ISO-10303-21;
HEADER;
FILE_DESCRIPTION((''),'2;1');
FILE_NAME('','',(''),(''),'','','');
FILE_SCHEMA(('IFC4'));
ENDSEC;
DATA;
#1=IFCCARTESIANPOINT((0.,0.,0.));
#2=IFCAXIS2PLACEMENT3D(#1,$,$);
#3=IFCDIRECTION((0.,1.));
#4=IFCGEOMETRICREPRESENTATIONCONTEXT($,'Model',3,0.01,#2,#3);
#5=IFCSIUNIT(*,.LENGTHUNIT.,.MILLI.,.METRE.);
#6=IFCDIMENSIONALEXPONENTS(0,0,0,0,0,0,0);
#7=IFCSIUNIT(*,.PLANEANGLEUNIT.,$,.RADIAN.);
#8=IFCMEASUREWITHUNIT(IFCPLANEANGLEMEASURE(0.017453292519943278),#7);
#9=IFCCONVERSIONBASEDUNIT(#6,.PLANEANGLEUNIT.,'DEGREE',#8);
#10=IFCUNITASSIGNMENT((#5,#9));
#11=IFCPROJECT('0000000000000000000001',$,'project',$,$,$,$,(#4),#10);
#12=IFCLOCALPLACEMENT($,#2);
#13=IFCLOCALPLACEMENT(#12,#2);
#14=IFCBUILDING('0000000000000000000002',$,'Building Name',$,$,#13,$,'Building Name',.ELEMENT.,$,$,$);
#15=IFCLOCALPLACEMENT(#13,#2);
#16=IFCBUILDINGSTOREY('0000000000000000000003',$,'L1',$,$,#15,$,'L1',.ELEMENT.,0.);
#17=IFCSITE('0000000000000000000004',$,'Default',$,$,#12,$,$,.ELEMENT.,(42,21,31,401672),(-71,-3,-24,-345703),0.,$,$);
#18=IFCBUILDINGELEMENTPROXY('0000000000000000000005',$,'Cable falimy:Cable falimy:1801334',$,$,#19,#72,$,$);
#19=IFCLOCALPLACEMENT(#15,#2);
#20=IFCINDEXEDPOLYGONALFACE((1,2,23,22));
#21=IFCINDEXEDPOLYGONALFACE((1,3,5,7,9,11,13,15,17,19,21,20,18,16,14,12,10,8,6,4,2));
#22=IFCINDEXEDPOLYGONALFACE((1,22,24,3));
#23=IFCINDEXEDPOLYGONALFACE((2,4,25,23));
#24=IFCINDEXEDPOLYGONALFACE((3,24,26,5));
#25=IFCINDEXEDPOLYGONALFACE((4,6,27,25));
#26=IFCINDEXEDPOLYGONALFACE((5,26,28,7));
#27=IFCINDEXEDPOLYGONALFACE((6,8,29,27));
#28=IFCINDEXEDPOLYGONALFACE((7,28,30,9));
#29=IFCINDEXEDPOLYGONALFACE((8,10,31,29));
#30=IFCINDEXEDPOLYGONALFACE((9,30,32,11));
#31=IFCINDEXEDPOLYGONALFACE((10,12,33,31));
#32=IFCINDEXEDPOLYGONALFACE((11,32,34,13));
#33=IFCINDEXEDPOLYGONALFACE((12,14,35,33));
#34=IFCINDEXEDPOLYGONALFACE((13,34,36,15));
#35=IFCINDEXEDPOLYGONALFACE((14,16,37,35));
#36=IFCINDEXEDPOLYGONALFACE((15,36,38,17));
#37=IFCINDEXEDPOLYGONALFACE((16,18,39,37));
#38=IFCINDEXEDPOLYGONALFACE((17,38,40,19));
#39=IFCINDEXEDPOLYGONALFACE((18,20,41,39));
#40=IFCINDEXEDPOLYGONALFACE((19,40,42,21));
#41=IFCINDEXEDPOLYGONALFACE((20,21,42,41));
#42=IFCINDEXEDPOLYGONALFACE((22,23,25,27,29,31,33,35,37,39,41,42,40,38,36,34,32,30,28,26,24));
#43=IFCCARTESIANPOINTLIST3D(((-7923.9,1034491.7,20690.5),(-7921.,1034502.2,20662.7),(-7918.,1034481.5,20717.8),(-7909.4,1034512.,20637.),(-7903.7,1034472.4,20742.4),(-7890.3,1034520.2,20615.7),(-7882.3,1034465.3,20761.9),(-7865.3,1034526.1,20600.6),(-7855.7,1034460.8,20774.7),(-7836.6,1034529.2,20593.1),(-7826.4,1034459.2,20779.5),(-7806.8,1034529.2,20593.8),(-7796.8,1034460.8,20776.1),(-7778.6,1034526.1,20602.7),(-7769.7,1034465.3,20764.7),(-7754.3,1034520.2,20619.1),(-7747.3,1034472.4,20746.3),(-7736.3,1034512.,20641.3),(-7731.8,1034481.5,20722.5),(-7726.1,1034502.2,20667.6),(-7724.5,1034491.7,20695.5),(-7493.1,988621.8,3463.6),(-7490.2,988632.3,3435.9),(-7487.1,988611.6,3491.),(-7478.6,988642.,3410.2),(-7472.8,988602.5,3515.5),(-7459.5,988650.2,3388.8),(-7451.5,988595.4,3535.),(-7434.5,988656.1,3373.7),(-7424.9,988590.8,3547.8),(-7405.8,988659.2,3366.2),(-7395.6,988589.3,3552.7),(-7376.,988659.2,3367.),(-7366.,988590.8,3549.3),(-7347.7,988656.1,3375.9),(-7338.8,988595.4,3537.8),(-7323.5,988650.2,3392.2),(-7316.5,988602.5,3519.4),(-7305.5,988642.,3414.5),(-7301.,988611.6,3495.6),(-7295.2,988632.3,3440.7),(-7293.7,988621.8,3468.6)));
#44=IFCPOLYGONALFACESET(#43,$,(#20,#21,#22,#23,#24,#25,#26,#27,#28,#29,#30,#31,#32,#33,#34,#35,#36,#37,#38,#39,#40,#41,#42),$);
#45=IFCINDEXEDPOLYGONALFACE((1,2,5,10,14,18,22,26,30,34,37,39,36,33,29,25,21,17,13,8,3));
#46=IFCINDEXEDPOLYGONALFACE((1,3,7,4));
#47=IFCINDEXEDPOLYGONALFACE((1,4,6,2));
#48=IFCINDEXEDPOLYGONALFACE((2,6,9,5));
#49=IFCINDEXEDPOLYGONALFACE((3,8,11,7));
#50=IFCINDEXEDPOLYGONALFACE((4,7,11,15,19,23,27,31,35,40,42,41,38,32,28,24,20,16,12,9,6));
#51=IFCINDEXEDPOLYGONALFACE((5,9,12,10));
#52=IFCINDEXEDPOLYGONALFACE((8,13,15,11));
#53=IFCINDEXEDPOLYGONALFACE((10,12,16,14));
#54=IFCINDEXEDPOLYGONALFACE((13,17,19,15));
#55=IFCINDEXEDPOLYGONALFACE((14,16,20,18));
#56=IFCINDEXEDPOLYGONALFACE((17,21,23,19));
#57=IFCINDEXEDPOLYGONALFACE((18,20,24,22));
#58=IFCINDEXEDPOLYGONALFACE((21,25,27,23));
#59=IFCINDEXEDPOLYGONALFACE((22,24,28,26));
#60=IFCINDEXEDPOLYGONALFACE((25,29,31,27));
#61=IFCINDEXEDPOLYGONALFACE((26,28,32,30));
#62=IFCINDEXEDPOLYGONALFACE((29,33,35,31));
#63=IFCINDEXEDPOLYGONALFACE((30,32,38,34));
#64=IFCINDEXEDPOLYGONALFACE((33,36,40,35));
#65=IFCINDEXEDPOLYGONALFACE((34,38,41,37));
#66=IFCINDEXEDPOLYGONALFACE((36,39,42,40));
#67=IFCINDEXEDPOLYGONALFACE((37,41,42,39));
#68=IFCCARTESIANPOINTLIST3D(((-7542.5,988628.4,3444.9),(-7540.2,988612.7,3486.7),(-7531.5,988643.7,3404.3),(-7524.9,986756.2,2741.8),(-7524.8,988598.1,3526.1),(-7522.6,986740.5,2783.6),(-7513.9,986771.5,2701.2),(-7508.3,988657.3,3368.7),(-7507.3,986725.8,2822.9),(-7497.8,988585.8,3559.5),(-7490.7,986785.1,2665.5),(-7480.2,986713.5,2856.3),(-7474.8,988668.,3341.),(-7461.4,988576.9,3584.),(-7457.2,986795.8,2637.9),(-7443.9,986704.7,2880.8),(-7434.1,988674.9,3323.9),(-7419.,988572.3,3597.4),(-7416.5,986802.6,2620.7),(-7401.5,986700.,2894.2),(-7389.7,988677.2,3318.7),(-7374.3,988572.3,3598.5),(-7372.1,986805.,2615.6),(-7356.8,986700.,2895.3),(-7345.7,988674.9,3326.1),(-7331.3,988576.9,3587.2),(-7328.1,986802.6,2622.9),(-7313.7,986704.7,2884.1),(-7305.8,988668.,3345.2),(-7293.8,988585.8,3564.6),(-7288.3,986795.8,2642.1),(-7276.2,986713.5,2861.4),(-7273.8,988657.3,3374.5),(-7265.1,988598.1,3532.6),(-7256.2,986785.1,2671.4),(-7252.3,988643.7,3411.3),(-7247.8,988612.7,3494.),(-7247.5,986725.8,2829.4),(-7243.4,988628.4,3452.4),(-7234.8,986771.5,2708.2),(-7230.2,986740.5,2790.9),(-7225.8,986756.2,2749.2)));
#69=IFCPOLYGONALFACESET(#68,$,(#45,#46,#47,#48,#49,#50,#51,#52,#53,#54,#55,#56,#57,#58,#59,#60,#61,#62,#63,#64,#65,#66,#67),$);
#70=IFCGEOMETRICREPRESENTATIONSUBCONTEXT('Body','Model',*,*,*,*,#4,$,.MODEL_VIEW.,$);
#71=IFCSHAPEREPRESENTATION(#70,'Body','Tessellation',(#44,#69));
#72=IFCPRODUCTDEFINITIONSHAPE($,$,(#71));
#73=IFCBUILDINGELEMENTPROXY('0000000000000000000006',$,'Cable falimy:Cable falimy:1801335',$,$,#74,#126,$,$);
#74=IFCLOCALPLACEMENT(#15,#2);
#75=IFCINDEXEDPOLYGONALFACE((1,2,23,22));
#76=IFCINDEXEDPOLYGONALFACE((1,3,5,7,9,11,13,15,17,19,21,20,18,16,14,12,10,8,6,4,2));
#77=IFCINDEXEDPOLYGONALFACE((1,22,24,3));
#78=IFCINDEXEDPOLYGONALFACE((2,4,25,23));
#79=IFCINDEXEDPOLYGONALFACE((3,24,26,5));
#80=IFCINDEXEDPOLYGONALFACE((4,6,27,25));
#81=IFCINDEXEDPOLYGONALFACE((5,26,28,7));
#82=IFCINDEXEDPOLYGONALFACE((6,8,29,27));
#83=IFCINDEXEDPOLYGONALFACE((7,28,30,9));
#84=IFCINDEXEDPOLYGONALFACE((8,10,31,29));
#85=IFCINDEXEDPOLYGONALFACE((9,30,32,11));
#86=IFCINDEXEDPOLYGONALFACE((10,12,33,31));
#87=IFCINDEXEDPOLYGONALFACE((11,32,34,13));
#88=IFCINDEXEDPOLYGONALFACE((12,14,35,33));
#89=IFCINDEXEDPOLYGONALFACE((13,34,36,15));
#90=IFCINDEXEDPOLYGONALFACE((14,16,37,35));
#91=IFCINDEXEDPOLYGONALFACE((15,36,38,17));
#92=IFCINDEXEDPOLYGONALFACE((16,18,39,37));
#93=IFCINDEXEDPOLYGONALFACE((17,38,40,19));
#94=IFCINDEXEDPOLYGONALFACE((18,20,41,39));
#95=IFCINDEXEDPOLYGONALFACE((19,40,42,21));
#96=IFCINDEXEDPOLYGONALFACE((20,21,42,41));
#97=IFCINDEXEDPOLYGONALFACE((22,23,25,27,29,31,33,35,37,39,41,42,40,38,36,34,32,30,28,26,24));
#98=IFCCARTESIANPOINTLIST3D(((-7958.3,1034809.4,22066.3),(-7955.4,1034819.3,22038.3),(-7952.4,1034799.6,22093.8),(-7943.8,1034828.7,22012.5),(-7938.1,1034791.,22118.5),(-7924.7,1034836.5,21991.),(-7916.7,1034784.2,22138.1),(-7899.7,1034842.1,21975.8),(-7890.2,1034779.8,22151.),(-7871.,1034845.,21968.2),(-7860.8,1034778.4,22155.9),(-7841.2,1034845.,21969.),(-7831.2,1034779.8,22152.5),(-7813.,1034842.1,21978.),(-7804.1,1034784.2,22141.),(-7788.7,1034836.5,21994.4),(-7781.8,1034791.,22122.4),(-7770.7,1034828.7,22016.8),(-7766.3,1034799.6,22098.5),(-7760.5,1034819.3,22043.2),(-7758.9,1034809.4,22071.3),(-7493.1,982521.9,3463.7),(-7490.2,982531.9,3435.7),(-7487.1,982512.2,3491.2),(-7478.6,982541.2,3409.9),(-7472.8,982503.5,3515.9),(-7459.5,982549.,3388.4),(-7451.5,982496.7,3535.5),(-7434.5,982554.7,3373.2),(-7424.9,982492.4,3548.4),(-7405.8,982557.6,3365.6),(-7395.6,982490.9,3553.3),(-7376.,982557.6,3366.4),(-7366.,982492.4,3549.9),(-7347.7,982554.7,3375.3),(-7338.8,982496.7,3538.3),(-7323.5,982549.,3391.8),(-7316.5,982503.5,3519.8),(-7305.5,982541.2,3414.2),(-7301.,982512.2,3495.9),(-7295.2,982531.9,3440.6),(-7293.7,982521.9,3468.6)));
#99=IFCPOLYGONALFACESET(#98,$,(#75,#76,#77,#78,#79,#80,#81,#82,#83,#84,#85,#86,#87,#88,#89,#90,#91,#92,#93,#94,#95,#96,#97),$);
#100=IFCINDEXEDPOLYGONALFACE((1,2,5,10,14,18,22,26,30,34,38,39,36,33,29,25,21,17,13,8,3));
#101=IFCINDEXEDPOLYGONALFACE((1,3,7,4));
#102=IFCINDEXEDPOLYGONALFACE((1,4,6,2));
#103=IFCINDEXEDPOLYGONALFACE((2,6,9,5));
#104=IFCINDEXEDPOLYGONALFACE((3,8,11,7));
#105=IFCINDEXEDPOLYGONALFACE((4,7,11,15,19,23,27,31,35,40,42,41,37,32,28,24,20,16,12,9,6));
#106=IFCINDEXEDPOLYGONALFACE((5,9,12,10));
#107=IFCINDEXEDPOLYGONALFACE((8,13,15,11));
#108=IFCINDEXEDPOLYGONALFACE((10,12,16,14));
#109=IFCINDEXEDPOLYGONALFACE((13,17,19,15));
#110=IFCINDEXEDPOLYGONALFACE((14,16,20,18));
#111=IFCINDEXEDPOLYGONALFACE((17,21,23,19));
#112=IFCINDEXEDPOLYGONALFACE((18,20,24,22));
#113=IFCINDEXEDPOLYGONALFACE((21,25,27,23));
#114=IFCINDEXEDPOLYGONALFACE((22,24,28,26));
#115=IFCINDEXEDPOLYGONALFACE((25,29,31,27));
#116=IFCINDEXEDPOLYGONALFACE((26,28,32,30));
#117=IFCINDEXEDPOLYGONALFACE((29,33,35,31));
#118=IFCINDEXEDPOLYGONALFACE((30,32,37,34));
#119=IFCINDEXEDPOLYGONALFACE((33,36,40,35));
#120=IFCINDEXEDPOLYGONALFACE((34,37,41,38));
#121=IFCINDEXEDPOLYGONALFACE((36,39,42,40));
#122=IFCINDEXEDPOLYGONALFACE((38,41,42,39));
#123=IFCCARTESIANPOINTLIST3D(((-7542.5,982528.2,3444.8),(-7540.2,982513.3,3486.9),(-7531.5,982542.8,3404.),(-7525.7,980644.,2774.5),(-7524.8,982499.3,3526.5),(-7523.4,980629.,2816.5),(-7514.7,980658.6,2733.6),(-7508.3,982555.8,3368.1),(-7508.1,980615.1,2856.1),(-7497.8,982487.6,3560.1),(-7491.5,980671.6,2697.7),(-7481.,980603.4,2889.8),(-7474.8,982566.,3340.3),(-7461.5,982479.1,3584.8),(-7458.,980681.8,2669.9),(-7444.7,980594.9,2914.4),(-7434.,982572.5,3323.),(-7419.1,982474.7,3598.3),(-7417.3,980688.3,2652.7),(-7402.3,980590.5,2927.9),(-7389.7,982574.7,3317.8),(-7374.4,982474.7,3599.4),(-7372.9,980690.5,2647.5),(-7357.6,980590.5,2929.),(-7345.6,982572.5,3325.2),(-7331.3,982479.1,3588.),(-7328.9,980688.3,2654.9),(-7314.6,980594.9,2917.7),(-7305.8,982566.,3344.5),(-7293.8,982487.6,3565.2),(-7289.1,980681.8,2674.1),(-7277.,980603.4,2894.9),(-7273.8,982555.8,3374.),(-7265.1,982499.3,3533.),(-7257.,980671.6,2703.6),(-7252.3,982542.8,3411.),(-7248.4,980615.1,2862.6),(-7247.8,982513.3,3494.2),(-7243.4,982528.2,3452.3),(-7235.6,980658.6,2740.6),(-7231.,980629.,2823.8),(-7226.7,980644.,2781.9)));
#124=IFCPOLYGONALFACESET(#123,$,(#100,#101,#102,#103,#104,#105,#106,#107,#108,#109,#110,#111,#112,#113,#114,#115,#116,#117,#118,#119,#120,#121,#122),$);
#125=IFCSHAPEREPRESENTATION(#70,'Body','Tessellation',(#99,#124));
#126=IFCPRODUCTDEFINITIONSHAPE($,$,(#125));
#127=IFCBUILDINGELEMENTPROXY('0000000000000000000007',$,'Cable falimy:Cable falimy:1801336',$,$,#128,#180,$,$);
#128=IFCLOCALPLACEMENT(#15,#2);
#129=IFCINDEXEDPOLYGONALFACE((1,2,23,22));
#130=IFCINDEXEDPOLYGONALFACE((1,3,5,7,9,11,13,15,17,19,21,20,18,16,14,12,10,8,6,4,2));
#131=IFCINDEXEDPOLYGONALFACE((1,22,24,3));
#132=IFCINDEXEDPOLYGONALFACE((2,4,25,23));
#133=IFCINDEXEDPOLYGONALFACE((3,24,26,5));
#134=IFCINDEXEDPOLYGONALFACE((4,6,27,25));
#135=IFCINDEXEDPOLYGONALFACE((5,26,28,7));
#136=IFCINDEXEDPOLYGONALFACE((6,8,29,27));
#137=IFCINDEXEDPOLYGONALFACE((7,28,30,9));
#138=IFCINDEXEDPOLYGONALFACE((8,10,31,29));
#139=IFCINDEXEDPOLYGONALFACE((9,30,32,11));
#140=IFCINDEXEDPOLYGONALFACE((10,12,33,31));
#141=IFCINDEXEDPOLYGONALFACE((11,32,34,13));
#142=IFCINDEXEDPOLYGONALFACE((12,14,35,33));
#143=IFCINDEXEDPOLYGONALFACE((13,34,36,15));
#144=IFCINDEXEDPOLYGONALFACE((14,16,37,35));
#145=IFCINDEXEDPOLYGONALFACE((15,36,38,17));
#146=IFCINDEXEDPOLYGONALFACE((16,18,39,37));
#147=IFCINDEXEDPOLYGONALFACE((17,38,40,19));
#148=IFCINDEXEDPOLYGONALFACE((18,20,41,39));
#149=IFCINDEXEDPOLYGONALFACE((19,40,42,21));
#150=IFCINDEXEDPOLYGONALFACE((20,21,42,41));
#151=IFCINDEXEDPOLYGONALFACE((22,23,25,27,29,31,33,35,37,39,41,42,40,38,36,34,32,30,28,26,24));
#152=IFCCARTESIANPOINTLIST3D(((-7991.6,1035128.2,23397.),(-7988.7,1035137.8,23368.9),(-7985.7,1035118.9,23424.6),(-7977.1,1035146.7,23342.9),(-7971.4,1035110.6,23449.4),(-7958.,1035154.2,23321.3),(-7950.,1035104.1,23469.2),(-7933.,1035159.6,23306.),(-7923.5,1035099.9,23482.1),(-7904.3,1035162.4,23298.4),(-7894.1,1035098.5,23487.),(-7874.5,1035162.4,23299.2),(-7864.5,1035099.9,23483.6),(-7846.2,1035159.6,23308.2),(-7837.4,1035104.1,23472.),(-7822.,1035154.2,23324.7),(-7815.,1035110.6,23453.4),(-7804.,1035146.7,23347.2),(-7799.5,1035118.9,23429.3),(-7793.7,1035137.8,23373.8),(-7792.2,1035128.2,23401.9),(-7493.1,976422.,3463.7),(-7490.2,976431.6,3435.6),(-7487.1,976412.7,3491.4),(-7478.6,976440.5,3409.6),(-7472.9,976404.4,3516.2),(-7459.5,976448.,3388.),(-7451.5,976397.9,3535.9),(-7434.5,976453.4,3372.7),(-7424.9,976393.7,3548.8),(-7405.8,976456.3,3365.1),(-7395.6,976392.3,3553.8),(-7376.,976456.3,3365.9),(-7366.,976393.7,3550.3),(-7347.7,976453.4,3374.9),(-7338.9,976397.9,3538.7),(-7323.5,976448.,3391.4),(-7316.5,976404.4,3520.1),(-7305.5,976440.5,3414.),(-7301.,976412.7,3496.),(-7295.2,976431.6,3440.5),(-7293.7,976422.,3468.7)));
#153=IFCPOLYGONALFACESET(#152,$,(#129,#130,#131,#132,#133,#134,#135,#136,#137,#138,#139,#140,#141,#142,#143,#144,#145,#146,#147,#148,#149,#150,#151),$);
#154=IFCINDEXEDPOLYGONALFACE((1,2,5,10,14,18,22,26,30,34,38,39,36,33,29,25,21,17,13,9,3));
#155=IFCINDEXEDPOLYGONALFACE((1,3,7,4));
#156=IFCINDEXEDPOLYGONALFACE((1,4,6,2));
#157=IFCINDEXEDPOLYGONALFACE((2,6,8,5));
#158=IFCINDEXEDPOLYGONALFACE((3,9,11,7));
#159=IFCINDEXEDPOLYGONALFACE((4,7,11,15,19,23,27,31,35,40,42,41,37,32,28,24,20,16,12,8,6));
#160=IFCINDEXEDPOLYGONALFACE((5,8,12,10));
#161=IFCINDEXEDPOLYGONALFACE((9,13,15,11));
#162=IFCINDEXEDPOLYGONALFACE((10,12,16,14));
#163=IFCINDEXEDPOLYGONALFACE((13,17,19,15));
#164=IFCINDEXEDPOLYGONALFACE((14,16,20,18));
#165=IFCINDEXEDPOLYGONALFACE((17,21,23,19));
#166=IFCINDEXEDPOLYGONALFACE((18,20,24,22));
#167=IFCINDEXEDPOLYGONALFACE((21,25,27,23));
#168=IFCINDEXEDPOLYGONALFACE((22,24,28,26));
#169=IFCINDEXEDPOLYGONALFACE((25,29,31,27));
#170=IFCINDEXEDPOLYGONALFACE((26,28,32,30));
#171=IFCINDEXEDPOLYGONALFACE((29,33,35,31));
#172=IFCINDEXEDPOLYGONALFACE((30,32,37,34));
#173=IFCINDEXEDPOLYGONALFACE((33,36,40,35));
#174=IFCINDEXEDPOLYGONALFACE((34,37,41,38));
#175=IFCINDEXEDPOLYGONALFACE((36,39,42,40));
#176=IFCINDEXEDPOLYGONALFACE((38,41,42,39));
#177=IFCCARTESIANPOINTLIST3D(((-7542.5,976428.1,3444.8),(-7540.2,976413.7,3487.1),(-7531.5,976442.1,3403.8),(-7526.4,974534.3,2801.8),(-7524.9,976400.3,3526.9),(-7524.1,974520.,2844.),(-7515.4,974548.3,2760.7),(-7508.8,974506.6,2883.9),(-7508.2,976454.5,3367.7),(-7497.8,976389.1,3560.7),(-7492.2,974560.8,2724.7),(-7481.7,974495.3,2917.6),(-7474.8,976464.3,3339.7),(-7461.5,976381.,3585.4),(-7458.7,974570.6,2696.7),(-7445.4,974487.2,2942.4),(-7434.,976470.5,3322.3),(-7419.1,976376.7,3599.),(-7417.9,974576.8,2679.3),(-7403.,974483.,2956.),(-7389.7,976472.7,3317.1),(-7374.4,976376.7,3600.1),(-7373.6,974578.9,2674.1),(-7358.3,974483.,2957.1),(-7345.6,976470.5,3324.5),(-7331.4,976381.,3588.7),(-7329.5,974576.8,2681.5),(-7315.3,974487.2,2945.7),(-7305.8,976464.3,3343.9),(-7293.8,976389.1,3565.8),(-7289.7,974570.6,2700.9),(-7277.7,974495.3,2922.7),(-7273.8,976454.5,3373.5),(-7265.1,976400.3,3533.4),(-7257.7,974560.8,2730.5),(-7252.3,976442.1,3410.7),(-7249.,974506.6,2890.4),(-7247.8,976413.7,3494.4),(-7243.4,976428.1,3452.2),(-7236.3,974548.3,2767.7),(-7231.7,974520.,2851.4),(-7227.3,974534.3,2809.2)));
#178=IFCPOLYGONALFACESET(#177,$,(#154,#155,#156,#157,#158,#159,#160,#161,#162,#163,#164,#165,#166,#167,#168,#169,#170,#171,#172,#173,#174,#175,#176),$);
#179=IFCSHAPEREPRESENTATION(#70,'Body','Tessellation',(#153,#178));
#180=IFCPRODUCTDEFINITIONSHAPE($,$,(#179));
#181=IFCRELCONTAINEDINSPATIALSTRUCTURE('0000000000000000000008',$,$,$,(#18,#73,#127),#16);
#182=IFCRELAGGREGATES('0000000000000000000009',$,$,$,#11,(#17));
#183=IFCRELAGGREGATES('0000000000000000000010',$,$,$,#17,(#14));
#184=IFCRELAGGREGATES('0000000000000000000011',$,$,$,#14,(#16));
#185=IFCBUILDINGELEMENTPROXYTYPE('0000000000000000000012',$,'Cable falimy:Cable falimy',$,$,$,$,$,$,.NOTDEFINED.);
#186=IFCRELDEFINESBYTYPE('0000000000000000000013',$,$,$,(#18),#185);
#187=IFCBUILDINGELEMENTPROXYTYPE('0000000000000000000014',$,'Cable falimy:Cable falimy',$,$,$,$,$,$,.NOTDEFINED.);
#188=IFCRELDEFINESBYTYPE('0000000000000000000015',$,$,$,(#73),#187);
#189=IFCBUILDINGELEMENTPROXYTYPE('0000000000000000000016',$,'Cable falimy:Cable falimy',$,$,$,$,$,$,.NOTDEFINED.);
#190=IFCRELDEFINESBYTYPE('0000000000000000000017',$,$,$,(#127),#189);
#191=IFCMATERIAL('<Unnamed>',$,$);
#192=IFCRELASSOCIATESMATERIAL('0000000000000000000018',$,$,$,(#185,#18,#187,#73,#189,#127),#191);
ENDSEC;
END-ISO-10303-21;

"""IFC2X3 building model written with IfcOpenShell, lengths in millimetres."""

from ifc_helpers import new_model, entity, si_unit, converted_unit, direction, frame, frame_2d, origin, place, context, subcontext, project, spatial, circle, extrude, source, transform, mapped, material, type_object, type_shapes, element, save


model = new_model("IFC2X3")

# Units and contexts
model_context = context("Model", 3, precision=0.01, world=origin(), true_north=direction((0.0, 1.0)))
body_context = subcontext(model_context, "Body", "Model", "MODEL_VIEW")
ifc_project = project(units=[si_unit("LENGTHUNIT", "METRE", prefix="MILLI"), converted_unit("PLANEANGLEUNIT", "DEGREE", entity("IfcPlaneAngleMeasure", 0.017453292519943278), si_unit("PLANEANGLEUNIT", "RADIAN"), dimensions=[0, 0, 0, 0, 0, 0, 0])], contexts=[model_context])

# Site, building, storey
site_placement = place(None, origin())
site = spatial("IfcSite", under=ifc_project, at=site_placement, Name="Default", CompositionType="ELEMENT", RefLatitude=(42, 21, 31, 401672), RefLongitude=(-71, -3, -24, -345703), RefElevation=0.0)
building_placement = place(site_placement, origin())
building = spatial("IfcBuilding", under=site, at=building_placement, Name="Building Name", LongName="Building Name", CompositionType="ELEMENT")
storey_placement = place(building_placement, origin())
storey = spatial("IfcBuildingStorey", under=building, at=storey_placement, Name="L1", LongName="L1", CompositionType="ELEMENT", Elevation=0.0)

# Shared definitions
ifc_material = material(Name="<Unnamed>")

# Building element proxies
building_element_proxy_type_1 = type_object("IfcBuildingElementProxyType", Name="Cable falimy:Cable falimy", PredefinedType="NOTDEFINED", material=ifc_material)
shared_shape_1 = source(origin(), body_context, "Body", "SweptSolid", [
    extrude(circle(Radius=100.0, at=frame_2d((0.0, 0.0), x_axis=(1.0, 0.0))), frame((0.0, 0.0, 0.0), z_axis=(0.936121, 0.0, 0.351678), x_axis=(-0.351678, 0.0, 0.936121)), (0.0, 0.0, 1.0), 49000.0),
    extrude(circle(Radius=150.0, at=frame_2d((0.0, 0.0), x_axis=(1.0, 0.0))), frame((-1872.2, 0.0, -703.4), z_axis=(0.936121, 0.0, 0.351678), x_axis=(0.351678, 0.0, -0.936121)), (0.0, 0.0, 1.0), 2000.0),
])
type_shapes(building_element_proxy_type_1, [shared_shape_1])
proxy_1_placement = place(storey_placement, frame((-7393.2, 988624.5, 3459.1), z_axis=(-0.025001, 0.0, 0.999687), x_axis=(0.0, 1.0, 0.0)))
element("IfcBuildingElementProxy", 1, at=proxy_1_placement, inside=storey, type_object=building_element_proxy_type_1, material=ifc_material, Name="Cable falimy:Cable falimy:1801334", context=body_context, shape_type="MappedRepresentation", body=[
    mapped(shared_shape_1, transform((0.0, 0.0, 0.0), scale=1.0)),
])
building_element_proxy_type_2 = type_object("IfcBuildingElementProxyType", Name="Cable falimy:Cable falimy", PredefinedType="NOTDEFINED", material=ifc_material)
shared_shape_2 = source(origin(), body_context, "Body", "SweptSolid", [
    extrude(circle(Radius=100.0, at=frame_2d((0.0, 0.0), x_axis=(1.0, 0.0))), frame((0.0, 0.0, 0.0), z_axis=(0.942116, 0.0, 0.335287), x_axis=(-0.335287, 0.0, 0.942116)), (0.0, 0.0, 1.0), 55500.0),
    extrude(circle(Radius=150.0, at=frame_2d((0.0, 0.0), x_axis=(1.0, 0.0))), frame((-1884.2, 0.0, -670.6), z_axis=(0.942116, 0.0, 0.335287), x_axis=(0.335287, 0.0, -0.942116)), (0.0, 0.0, 1.0), 2000.0),
])
type_shapes(building_element_proxy_type_2, [shared_shape_2])
proxy_2_placement = place(storey_placement, frame((-7393.2, 982524.5, 3459.1), z_axis=(-0.025001, 0.0, 0.999687), x_axis=(0.0, 1.0, 0.0)))
element("IfcBuildingElementProxy", 2, at=proxy_2_placement, inside=storey, type_object=building_element_proxy_type_2, material=ifc_material, Name="Cable falimy:Cable falimy:1801335", context=body_context, shape_type="MappedRepresentation", body=[
    mapped(shared_shape_2, transform((0.0, 0.0, 0.0), scale=1.0)),
])
building_element_proxy_type_3 = type_object("IfcBuildingElementProxyType", Name="Cable falimy:Cable falimy", PredefinedType="NOTDEFINED", material=ifc_material)
shared_shape_3 = source(origin(), body_context, "Body", "SweptSolid", [
    extrude(circle(Radius=100.0, at=frame_2d((0.0, 0.0), x_axis=(1.0, 0.0))), frame((0.0, 0.0, 0.0), z_axis=(0.946874, 0.0, 0.321605), x_axis=(-0.321605, 0.0, 0.946874)), (0.0, 0.0, 1.0), 62000.0),
    extrude(circle(Radius=150.0, at=frame_2d((0.0, 0.0), x_axis=(1.0, 0.0))), frame((-1893.7, 0.0, -643.2), z_axis=(0.946874, 0.0, 0.321605), x_axis=(0.321605, 0.0, -0.946874)), (0.0, 0.0, 1.0), 2000.0),
])
type_shapes(building_element_proxy_type_3, [shared_shape_3])
proxy_3_placement = place(storey_placement, frame((-7393.2, 976424.5, 3459.1), z_axis=(-0.025001, 0.0, 0.999687), x_axis=(0.0, 1.0, 0.0)))
element("IfcBuildingElementProxy", 3, at=proxy_3_placement, inside=storey, type_object=building_element_proxy_type_3, material=ifc_material, Name="Cable falimy:Cable falimy:1801336", context=body_context, shape_type="MappedRepresentation", body=[
    mapped(shared_shape_3, transform((0.0, 0.0, 0.0), scale=1.0)),
])

save(model, "model.ifc")
